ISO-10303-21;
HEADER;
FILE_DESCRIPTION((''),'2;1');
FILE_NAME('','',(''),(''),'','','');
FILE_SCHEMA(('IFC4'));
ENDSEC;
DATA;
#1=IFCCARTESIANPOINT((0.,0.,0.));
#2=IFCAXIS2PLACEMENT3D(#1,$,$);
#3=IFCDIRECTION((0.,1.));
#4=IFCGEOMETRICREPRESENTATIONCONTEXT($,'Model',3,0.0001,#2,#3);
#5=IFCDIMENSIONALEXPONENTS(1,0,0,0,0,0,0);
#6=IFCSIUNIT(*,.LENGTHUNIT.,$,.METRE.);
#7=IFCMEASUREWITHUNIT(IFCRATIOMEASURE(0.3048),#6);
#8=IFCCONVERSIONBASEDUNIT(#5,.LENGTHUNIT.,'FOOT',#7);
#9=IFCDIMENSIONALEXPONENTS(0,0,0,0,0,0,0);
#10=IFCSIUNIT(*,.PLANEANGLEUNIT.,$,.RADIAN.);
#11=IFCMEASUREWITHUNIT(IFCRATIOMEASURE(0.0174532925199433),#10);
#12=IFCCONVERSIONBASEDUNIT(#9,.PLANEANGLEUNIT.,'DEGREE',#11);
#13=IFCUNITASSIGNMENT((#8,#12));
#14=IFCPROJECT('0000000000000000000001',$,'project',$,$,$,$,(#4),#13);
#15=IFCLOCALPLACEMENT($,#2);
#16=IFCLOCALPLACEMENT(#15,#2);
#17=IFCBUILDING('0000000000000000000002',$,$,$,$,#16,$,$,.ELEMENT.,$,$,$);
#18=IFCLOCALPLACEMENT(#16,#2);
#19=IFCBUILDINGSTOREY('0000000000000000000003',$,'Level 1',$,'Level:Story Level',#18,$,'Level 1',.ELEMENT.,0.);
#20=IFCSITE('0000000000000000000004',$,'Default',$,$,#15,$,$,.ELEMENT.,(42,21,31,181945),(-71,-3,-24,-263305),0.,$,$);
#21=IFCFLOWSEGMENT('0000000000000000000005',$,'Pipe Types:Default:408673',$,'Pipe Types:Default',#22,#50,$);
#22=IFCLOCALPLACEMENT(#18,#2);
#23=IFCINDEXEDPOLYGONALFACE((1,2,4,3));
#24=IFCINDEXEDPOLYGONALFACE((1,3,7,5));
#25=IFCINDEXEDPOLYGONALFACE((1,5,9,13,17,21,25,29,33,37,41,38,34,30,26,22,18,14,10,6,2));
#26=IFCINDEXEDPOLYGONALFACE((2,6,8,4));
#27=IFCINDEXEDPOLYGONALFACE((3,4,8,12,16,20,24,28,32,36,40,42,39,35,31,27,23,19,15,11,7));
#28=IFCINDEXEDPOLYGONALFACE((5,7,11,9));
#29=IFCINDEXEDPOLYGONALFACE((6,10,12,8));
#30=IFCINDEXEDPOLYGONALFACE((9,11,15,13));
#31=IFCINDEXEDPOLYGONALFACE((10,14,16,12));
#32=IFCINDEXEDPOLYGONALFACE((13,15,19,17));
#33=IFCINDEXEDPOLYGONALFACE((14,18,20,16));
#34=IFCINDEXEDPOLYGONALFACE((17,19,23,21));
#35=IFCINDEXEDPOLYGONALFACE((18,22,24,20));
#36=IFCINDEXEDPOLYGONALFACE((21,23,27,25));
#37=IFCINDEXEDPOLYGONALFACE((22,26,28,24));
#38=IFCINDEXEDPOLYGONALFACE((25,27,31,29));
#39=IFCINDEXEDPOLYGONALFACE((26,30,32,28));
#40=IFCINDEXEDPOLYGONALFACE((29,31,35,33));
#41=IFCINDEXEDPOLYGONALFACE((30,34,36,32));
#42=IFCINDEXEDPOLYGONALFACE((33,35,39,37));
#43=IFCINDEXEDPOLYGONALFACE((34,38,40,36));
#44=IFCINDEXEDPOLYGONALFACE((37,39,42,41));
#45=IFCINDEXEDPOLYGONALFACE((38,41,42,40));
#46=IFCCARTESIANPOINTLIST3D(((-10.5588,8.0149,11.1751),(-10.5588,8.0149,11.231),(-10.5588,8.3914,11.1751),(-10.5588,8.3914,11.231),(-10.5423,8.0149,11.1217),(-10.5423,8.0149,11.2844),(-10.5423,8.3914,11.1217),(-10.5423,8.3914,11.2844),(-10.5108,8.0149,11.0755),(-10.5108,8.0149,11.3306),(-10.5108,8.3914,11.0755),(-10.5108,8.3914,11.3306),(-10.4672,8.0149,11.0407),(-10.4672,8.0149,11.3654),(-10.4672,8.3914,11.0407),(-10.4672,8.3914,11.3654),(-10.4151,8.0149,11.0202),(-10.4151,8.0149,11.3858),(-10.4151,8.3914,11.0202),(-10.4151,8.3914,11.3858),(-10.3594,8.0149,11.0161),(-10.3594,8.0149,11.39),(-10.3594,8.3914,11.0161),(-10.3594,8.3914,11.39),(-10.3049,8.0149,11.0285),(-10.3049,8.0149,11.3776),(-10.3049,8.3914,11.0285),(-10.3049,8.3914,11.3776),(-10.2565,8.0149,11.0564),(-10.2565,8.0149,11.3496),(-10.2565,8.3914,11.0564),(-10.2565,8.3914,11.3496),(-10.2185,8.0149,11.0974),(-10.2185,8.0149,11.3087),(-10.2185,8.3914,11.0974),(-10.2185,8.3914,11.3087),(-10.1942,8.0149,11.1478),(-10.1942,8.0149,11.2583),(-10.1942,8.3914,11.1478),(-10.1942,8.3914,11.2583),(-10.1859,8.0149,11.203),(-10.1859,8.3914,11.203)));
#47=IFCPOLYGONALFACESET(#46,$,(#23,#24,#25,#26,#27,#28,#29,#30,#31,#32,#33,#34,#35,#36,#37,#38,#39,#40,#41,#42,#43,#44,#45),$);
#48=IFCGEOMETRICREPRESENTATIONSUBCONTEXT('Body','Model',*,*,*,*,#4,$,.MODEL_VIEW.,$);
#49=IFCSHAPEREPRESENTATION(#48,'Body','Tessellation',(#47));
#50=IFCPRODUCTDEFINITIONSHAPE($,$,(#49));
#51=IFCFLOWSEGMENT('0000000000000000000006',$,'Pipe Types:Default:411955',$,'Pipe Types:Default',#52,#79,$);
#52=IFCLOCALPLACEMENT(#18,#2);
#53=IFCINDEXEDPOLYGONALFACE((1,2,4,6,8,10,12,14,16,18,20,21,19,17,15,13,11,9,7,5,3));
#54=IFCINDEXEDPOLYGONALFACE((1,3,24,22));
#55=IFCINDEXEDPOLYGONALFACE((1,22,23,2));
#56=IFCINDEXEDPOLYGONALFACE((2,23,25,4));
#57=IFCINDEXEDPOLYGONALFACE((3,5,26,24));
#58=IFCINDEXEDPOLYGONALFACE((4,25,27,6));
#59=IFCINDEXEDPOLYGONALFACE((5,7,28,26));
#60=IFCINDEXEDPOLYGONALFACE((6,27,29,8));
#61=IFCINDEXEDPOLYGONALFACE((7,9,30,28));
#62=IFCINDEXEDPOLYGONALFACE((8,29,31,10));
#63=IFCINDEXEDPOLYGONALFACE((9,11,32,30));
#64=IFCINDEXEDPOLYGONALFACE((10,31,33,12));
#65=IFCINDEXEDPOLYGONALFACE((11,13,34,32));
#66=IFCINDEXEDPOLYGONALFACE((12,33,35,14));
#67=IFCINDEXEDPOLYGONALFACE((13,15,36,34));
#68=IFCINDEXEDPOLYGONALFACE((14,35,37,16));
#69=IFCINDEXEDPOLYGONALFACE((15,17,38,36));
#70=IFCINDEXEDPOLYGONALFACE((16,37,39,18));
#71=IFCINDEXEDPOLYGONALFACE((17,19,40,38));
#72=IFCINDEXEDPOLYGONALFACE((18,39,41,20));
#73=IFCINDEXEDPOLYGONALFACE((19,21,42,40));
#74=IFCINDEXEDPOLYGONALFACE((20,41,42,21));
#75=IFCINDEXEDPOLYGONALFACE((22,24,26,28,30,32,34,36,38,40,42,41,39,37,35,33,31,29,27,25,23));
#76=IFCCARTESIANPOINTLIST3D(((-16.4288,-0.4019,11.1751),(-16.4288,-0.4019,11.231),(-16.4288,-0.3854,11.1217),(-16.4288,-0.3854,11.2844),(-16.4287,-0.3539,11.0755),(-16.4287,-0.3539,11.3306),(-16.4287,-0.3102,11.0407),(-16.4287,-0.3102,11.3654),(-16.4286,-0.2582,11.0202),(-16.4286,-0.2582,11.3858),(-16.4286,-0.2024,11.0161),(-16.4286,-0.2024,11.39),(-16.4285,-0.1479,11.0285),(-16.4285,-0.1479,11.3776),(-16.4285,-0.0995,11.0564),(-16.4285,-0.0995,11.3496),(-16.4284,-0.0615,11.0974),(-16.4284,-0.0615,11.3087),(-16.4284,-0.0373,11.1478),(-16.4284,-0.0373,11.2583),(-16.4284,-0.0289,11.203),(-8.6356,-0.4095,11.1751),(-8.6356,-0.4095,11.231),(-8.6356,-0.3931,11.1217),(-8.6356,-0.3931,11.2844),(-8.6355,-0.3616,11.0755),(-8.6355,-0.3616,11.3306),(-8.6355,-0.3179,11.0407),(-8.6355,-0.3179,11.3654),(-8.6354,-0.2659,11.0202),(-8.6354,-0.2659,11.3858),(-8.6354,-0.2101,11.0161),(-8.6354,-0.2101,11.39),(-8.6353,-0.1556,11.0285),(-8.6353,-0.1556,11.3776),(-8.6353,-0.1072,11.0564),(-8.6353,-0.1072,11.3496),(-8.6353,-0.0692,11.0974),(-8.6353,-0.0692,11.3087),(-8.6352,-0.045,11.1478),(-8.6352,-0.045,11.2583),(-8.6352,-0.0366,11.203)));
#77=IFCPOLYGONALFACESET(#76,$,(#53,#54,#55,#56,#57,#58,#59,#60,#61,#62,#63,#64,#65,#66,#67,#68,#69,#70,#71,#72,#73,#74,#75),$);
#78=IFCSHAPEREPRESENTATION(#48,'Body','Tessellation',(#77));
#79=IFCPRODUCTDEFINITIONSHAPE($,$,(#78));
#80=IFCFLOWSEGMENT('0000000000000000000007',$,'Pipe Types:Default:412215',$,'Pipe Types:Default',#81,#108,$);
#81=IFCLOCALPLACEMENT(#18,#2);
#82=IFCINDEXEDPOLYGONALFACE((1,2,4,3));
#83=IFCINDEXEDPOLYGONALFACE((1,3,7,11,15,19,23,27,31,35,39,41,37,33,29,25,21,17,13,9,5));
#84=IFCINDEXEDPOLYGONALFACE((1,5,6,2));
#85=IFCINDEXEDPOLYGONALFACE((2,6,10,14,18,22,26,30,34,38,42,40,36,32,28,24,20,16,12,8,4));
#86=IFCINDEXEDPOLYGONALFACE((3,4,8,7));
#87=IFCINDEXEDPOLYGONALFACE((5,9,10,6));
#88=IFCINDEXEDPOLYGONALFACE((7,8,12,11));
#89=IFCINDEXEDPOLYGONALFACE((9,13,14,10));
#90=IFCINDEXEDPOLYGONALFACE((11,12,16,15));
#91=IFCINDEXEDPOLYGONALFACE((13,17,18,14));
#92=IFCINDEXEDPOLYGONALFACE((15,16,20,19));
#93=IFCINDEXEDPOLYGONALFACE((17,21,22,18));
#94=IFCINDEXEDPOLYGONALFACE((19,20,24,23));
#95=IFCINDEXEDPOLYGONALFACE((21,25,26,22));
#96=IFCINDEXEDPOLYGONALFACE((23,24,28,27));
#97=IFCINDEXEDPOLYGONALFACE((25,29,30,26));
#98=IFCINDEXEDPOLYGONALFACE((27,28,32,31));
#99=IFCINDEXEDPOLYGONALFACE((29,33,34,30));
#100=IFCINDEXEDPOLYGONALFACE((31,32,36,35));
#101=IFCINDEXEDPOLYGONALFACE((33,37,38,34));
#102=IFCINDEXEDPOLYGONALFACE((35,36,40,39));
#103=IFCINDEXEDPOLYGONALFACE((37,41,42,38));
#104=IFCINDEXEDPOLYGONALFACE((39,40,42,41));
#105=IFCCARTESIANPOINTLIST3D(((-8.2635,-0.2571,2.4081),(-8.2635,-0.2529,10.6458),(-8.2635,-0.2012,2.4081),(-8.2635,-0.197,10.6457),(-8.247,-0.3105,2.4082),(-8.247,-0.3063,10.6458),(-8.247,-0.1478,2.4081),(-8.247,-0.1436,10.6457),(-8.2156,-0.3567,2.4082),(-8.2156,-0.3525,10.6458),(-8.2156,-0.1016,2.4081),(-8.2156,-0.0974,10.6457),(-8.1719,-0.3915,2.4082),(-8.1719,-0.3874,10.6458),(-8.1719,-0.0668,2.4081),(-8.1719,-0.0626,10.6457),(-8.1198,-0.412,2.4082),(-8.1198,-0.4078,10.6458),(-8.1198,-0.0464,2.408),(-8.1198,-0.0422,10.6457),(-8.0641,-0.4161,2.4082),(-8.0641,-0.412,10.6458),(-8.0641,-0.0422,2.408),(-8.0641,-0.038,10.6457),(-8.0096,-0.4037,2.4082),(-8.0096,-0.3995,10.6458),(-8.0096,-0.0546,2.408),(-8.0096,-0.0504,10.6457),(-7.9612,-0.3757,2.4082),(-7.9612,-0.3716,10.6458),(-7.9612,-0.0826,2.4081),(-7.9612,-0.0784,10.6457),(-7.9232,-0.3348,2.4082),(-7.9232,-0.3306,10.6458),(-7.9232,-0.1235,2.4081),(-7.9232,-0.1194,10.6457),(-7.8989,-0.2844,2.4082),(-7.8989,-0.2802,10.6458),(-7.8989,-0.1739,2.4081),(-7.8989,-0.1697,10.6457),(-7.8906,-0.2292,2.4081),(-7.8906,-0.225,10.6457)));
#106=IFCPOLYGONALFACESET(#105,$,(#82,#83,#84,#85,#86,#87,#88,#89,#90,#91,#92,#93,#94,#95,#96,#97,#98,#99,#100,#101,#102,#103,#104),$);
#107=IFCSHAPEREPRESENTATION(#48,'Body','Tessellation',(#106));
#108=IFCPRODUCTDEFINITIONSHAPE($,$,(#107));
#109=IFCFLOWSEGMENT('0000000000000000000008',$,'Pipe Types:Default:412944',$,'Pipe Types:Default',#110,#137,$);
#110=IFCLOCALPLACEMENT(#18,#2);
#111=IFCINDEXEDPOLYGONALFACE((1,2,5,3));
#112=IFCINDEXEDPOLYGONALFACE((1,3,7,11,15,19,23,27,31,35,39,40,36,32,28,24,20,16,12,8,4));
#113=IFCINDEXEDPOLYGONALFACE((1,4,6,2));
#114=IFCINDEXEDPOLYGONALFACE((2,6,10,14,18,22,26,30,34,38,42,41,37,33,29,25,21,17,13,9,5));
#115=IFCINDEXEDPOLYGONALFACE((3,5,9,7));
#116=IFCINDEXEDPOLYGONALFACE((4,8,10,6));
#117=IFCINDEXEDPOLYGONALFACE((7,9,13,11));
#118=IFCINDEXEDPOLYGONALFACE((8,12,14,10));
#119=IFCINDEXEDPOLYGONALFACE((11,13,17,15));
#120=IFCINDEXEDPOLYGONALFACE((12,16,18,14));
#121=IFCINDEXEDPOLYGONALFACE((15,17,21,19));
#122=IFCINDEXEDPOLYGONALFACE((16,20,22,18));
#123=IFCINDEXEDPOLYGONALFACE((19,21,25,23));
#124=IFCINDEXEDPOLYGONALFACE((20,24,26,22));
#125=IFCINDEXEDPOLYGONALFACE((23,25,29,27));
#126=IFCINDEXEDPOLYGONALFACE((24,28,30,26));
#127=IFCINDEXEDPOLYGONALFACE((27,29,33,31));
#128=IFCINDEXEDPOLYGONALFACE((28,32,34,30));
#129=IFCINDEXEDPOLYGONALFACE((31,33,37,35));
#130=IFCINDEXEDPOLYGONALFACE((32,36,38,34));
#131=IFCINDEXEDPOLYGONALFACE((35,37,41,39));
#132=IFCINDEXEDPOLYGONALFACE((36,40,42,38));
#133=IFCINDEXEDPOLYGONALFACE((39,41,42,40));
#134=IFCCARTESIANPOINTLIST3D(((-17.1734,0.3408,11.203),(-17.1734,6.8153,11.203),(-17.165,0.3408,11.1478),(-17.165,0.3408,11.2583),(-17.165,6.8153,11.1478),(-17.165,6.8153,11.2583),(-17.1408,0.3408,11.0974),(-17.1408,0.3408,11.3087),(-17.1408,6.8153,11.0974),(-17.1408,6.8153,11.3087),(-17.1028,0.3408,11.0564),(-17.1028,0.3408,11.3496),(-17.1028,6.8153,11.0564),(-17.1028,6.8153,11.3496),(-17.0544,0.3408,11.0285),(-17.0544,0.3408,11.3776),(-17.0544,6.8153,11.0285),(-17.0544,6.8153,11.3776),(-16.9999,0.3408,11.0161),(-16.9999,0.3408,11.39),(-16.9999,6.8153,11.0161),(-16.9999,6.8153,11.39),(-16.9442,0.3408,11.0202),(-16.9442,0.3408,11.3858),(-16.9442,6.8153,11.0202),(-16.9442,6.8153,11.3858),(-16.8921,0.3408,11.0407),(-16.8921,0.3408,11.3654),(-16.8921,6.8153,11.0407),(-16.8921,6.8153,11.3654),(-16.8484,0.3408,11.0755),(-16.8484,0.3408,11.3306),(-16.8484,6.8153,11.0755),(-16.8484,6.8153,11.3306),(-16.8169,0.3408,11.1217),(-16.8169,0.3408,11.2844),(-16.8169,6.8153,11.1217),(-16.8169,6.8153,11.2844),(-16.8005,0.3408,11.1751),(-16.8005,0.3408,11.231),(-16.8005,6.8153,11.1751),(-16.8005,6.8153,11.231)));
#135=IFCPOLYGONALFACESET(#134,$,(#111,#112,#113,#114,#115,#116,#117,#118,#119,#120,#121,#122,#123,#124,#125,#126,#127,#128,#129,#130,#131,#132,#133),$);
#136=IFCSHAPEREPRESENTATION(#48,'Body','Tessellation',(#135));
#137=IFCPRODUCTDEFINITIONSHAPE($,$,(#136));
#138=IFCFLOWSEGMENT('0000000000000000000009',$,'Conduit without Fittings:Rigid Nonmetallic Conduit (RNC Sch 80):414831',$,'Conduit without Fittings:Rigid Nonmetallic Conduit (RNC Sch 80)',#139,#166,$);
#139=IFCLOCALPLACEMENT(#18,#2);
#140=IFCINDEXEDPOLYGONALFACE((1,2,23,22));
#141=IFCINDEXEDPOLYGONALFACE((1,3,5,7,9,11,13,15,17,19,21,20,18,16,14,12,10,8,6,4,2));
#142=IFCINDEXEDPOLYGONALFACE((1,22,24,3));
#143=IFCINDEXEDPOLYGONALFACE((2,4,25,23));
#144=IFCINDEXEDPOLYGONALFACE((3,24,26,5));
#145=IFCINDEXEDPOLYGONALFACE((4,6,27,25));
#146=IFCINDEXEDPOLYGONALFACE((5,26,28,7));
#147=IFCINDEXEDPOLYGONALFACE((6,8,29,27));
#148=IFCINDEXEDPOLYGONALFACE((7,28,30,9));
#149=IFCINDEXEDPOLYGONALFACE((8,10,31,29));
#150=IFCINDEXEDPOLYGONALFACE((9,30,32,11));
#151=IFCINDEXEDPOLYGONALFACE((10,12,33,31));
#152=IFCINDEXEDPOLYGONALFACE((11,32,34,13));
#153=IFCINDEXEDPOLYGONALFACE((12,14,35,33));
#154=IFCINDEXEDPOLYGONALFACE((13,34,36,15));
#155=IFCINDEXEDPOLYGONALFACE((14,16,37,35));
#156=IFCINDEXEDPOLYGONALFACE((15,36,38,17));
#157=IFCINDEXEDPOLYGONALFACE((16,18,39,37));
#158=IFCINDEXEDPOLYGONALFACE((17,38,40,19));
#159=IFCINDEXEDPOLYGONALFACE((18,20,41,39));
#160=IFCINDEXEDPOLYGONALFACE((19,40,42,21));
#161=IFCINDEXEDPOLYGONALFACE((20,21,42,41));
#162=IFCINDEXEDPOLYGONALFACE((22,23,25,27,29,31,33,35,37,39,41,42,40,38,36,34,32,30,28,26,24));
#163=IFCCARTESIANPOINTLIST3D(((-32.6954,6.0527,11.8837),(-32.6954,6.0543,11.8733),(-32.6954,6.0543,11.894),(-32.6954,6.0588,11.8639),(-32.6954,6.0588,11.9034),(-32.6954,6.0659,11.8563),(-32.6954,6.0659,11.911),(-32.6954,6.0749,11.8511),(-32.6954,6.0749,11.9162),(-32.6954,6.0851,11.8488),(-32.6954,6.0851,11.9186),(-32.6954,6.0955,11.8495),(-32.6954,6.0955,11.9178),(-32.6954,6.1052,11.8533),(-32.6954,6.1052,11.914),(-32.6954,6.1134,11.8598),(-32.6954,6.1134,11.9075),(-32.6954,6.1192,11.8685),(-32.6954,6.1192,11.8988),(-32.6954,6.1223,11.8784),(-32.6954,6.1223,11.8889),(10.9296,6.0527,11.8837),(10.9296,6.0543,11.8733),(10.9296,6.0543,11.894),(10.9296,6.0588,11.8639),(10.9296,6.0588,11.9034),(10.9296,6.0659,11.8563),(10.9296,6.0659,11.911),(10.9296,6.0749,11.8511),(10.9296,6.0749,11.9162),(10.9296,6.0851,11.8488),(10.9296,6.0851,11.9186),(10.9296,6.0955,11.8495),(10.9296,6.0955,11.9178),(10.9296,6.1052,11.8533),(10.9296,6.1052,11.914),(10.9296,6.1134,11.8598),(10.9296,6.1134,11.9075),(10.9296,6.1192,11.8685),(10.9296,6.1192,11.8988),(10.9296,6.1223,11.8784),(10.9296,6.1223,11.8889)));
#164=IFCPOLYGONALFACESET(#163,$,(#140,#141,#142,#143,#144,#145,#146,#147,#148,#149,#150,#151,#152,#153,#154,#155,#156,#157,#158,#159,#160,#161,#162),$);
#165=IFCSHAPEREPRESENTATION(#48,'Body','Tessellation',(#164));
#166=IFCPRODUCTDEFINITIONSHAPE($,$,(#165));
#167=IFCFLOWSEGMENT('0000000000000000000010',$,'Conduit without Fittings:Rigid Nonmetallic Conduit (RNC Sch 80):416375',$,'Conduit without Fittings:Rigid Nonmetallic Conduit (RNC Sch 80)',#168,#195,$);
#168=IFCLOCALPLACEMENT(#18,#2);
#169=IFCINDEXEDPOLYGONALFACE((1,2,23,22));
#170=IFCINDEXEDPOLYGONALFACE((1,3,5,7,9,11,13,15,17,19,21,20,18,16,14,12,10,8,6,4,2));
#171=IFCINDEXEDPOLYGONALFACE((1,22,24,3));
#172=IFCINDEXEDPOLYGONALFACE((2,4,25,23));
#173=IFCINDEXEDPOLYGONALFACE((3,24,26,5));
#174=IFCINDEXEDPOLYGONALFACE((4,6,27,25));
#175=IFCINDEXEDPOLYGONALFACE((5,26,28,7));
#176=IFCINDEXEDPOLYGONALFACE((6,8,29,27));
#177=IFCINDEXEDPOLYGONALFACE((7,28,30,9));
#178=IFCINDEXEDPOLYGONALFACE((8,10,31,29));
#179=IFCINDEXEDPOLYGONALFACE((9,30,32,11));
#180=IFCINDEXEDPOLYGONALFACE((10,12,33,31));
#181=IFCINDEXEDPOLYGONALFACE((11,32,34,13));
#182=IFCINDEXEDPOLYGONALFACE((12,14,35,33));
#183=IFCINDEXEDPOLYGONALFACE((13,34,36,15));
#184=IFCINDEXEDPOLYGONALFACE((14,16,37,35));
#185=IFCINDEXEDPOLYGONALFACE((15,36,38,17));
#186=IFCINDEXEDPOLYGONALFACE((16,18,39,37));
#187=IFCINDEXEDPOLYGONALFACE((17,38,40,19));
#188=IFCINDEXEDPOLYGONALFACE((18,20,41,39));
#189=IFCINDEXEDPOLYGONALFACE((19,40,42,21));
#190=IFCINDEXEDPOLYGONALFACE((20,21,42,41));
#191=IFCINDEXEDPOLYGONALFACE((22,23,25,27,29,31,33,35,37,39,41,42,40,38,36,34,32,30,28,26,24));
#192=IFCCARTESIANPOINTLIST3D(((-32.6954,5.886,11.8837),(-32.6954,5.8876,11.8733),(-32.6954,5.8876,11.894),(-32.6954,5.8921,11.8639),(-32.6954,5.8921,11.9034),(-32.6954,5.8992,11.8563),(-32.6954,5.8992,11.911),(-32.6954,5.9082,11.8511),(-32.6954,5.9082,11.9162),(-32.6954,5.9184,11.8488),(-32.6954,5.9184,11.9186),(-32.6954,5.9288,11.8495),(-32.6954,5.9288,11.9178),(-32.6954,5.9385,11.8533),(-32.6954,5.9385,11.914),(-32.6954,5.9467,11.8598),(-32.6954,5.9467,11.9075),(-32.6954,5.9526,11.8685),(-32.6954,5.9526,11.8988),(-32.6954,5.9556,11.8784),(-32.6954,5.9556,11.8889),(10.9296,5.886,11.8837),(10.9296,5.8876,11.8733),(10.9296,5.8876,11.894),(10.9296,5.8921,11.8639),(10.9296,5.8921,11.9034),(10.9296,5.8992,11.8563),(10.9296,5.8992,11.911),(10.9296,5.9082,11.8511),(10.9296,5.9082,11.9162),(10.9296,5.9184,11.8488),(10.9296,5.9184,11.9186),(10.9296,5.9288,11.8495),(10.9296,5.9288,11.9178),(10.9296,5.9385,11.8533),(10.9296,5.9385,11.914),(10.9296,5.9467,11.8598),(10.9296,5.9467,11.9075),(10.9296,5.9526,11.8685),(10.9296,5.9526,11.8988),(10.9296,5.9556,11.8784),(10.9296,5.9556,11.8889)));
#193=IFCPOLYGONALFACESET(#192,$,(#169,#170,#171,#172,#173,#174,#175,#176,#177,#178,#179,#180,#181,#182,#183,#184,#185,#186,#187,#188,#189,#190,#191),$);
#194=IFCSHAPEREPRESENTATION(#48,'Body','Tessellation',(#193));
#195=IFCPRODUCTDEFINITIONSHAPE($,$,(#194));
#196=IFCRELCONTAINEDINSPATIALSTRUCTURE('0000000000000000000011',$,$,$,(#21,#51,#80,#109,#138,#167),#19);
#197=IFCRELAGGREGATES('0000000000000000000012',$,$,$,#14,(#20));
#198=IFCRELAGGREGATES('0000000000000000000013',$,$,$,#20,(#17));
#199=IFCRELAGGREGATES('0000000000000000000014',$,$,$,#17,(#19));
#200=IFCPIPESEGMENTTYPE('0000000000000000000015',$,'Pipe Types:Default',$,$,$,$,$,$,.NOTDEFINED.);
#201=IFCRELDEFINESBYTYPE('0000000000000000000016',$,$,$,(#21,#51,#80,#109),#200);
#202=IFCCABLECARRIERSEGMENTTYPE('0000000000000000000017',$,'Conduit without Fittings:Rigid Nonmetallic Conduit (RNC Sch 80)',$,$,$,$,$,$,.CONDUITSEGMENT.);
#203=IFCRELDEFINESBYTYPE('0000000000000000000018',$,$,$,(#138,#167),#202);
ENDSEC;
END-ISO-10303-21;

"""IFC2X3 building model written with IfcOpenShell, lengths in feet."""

from ifc_helpers import new_model, entity, si_unit, converted_unit, direction, frame, frame_2d, origin, origin_2d_with_axis, place, context, subcontext, project, spatial, circle, extrude, type_object, element, save


model = new_model("IFC2X3")

# Units and contexts
model_context = context("Model", 3, precision=0.0001, world=origin(), true_north=direction((0.0, 1.0)))
body_context = subcontext(model_context, "Body", "Model", "MODEL_VIEW")
ifc_project = project(units=[converted_unit("LENGTHUNIT", "FOOT", entity("IfcRatioMeasure", 0.3048), si_unit("LENGTHUNIT", "METRE"), dimensions=[1, 0, 0, 0, 0, 0, 0]), converted_unit("PLANEANGLEUNIT", "DEGREE", entity("IfcRatioMeasure", 0.0174532925199433), si_unit("PLANEANGLEUNIT", "RADIAN"), dimensions=[0, 0, 0, 0, 0, 0, 0])], contexts=[model_context])

# Site, building, storey
site_placement = place(None, origin())
site = spatial("IfcSite", under=ifc_project, at=site_placement, Name="Default", CompositionType="ELEMENT", RefLatitude=(42, 21, 31, 181945), RefLongitude=(-71, -3, -24, -263305), RefElevation=0.0)
building_placement = place(site_placement, origin())
building = spatial("IfcBuilding", under=site, at=building_placement, CompositionType="ELEMENT")
storey_placement = place(building_placement, origin())
storey = spatial("IfcBuildingStorey", under=building, at=storey_placement, Name="Level 1", ObjectType="Level:Story Level", LongName="Level 1", CompositionType="ELEMENT", Elevation=0.0)

# Flow segments
pipe_segment_type = type_object("IfcPipeSegmentType", Name="Pipe Types:Default", PredefinedType="NOTDEFINED")
flow_segment_1_placement = place(storey_placement, origin())
element("IfcFlowSegment", 1, at=flow_segment_1_placement, inside=storey, type_object=pipe_segment_type, Name="Pipe Types:Default:408673", ObjectType="Pipe Types:Default", context=body_context, shape_type="SweptSolid", body=[
    extrude(circle(Radius=0.1875, at=origin_2d_with_axis()), frame((-10.3734, 8.0149, 11.203), z_axis=(0.0, 1.0, 0.0), x_axis=(1.0, 0.0, 0.0)), (0.0, 0.0, 1.0), 0.3765),
])
flow_segment_2_placement = place(storey_placement, origin())
element("IfcFlowSegment", 2, at=flow_segment_2_placement, inside=storey, type_object=pipe_segment_type, Name="Pipe Types:Default:411955", ObjectType="Pipe Types:Default", context=body_context, shape_type="SweptSolid", body=[
    extrude(circle(Radius=0.1875, at=frame_2d((0.0, 0.0), x_axis=(1.0, 0.0))), frame((-16.4286, -0.2164, 11.203), z_axis=(1.0, -0.000986, 0.0), x_axis=(0.000986, 1.0, 0.0)), (0.0, 0.0, 1.0), 7.7932),
])
flow_segment_3_placement = place(storey_placement, origin())
element("IfcFlowSegment", 3, at=flow_segment_3_placement, inside=storey, type_object=pipe_segment_type, Name="Pipe Types:Default:412215", ObjectType="Pipe Types:Default", context=body_context, shape_type="SweptSolid", body=[
    extrude(circle(Radius=0.1875, at=frame_2d((0.0, 0.0), x_axis=(1.0, 0.0))), frame((-8.0781, -0.2292, 2.4081), z_axis=(0.0, 0.000507, 1.0), x_axis=(1.0, 0.0, 0.0)), (0.0, 0.0, 1.0), 8.2376),
])
flow_segment_4_placement = place(storey_placement, origin())
element("IfcFlowSegment", 4, at=flow_segment_4_placement, inside=storey, type_object=pipe_segment_type, Name="Pipe Types:Default:412944", ObjectType="Pipe Types:Default", context=body_context, shape_type="SweptSolid", body=[
    extrude(circle(Radius=0.1875, at=frame_2d((0.0, 0.0), x_axis=(1.0, 0.0))), frame((-16.9859, 0.3408, 11.203), z_axis=(0.0, 1.0, 0.0), x_axis=(-1.0, 0.0, 0.0)), (0.0, 0.0, 1.0), 6.4744),
])
cable_carrier_segment_type = type_object("IfcCableCarrierSegmentType", Name="Conduit without Fittings:Rigid Nonmetallic Conduit (RNC Sch 80)", PredefinedType="CONDUITSEGMENT")
flow_segment_5_placement = place(storey_placement, origin())
element("IfcFlowSegment", 5, at=flow_segment_5_placement, inside=storey, type_object=cable_carrier_segment_type, Name="Conduit without Fittings:Rigid Nonmetallic Conduit (RNC Sch 80):414831", ObjectType="Conduit without Fittings:Rigid Nonmetallic Conduit (RNC Sch 80)", context=body_context, shape_type="SweptSolid", body=[
    extrude(circle(Radius=0.035, at=origin_2d_with_axis()), frame((-32.6954, 6.0877, 11.8837), z_axis=(1.0, 0.0, 0.0), x_axis=(0.0, -1.0, 0.0)), (0.0, 0.0, 1.0), 43.625),
])
flow_segment_6_placement = place(storey_placement, origin())
element("IfcFlowSegment", 6, at=flow_segment_6_placement, inside=storey, type_object=cable_carrier_segment_type, Name="Conduit without Fittings:Rigid Nonmetallic Conduit (RNC Sch 80):416375", ObjectType="Conduit without Fittings:Rigid Nonmetallic Conduit (RNC Sch 80)", context=body_context, shape_type="SweptSolid", body=[
    extrude(circle(Radius=0.035, at=origin_2d_with_axis()), frame((-32.6954, 5.921, 11.8837), z_axis=(1.0, 0.0, 0.0), x_axis=(0.0, -1.0, 0.0)), (0.0, 0.0, 1.0), 43.625),
])

save(model, "model.ifc")
